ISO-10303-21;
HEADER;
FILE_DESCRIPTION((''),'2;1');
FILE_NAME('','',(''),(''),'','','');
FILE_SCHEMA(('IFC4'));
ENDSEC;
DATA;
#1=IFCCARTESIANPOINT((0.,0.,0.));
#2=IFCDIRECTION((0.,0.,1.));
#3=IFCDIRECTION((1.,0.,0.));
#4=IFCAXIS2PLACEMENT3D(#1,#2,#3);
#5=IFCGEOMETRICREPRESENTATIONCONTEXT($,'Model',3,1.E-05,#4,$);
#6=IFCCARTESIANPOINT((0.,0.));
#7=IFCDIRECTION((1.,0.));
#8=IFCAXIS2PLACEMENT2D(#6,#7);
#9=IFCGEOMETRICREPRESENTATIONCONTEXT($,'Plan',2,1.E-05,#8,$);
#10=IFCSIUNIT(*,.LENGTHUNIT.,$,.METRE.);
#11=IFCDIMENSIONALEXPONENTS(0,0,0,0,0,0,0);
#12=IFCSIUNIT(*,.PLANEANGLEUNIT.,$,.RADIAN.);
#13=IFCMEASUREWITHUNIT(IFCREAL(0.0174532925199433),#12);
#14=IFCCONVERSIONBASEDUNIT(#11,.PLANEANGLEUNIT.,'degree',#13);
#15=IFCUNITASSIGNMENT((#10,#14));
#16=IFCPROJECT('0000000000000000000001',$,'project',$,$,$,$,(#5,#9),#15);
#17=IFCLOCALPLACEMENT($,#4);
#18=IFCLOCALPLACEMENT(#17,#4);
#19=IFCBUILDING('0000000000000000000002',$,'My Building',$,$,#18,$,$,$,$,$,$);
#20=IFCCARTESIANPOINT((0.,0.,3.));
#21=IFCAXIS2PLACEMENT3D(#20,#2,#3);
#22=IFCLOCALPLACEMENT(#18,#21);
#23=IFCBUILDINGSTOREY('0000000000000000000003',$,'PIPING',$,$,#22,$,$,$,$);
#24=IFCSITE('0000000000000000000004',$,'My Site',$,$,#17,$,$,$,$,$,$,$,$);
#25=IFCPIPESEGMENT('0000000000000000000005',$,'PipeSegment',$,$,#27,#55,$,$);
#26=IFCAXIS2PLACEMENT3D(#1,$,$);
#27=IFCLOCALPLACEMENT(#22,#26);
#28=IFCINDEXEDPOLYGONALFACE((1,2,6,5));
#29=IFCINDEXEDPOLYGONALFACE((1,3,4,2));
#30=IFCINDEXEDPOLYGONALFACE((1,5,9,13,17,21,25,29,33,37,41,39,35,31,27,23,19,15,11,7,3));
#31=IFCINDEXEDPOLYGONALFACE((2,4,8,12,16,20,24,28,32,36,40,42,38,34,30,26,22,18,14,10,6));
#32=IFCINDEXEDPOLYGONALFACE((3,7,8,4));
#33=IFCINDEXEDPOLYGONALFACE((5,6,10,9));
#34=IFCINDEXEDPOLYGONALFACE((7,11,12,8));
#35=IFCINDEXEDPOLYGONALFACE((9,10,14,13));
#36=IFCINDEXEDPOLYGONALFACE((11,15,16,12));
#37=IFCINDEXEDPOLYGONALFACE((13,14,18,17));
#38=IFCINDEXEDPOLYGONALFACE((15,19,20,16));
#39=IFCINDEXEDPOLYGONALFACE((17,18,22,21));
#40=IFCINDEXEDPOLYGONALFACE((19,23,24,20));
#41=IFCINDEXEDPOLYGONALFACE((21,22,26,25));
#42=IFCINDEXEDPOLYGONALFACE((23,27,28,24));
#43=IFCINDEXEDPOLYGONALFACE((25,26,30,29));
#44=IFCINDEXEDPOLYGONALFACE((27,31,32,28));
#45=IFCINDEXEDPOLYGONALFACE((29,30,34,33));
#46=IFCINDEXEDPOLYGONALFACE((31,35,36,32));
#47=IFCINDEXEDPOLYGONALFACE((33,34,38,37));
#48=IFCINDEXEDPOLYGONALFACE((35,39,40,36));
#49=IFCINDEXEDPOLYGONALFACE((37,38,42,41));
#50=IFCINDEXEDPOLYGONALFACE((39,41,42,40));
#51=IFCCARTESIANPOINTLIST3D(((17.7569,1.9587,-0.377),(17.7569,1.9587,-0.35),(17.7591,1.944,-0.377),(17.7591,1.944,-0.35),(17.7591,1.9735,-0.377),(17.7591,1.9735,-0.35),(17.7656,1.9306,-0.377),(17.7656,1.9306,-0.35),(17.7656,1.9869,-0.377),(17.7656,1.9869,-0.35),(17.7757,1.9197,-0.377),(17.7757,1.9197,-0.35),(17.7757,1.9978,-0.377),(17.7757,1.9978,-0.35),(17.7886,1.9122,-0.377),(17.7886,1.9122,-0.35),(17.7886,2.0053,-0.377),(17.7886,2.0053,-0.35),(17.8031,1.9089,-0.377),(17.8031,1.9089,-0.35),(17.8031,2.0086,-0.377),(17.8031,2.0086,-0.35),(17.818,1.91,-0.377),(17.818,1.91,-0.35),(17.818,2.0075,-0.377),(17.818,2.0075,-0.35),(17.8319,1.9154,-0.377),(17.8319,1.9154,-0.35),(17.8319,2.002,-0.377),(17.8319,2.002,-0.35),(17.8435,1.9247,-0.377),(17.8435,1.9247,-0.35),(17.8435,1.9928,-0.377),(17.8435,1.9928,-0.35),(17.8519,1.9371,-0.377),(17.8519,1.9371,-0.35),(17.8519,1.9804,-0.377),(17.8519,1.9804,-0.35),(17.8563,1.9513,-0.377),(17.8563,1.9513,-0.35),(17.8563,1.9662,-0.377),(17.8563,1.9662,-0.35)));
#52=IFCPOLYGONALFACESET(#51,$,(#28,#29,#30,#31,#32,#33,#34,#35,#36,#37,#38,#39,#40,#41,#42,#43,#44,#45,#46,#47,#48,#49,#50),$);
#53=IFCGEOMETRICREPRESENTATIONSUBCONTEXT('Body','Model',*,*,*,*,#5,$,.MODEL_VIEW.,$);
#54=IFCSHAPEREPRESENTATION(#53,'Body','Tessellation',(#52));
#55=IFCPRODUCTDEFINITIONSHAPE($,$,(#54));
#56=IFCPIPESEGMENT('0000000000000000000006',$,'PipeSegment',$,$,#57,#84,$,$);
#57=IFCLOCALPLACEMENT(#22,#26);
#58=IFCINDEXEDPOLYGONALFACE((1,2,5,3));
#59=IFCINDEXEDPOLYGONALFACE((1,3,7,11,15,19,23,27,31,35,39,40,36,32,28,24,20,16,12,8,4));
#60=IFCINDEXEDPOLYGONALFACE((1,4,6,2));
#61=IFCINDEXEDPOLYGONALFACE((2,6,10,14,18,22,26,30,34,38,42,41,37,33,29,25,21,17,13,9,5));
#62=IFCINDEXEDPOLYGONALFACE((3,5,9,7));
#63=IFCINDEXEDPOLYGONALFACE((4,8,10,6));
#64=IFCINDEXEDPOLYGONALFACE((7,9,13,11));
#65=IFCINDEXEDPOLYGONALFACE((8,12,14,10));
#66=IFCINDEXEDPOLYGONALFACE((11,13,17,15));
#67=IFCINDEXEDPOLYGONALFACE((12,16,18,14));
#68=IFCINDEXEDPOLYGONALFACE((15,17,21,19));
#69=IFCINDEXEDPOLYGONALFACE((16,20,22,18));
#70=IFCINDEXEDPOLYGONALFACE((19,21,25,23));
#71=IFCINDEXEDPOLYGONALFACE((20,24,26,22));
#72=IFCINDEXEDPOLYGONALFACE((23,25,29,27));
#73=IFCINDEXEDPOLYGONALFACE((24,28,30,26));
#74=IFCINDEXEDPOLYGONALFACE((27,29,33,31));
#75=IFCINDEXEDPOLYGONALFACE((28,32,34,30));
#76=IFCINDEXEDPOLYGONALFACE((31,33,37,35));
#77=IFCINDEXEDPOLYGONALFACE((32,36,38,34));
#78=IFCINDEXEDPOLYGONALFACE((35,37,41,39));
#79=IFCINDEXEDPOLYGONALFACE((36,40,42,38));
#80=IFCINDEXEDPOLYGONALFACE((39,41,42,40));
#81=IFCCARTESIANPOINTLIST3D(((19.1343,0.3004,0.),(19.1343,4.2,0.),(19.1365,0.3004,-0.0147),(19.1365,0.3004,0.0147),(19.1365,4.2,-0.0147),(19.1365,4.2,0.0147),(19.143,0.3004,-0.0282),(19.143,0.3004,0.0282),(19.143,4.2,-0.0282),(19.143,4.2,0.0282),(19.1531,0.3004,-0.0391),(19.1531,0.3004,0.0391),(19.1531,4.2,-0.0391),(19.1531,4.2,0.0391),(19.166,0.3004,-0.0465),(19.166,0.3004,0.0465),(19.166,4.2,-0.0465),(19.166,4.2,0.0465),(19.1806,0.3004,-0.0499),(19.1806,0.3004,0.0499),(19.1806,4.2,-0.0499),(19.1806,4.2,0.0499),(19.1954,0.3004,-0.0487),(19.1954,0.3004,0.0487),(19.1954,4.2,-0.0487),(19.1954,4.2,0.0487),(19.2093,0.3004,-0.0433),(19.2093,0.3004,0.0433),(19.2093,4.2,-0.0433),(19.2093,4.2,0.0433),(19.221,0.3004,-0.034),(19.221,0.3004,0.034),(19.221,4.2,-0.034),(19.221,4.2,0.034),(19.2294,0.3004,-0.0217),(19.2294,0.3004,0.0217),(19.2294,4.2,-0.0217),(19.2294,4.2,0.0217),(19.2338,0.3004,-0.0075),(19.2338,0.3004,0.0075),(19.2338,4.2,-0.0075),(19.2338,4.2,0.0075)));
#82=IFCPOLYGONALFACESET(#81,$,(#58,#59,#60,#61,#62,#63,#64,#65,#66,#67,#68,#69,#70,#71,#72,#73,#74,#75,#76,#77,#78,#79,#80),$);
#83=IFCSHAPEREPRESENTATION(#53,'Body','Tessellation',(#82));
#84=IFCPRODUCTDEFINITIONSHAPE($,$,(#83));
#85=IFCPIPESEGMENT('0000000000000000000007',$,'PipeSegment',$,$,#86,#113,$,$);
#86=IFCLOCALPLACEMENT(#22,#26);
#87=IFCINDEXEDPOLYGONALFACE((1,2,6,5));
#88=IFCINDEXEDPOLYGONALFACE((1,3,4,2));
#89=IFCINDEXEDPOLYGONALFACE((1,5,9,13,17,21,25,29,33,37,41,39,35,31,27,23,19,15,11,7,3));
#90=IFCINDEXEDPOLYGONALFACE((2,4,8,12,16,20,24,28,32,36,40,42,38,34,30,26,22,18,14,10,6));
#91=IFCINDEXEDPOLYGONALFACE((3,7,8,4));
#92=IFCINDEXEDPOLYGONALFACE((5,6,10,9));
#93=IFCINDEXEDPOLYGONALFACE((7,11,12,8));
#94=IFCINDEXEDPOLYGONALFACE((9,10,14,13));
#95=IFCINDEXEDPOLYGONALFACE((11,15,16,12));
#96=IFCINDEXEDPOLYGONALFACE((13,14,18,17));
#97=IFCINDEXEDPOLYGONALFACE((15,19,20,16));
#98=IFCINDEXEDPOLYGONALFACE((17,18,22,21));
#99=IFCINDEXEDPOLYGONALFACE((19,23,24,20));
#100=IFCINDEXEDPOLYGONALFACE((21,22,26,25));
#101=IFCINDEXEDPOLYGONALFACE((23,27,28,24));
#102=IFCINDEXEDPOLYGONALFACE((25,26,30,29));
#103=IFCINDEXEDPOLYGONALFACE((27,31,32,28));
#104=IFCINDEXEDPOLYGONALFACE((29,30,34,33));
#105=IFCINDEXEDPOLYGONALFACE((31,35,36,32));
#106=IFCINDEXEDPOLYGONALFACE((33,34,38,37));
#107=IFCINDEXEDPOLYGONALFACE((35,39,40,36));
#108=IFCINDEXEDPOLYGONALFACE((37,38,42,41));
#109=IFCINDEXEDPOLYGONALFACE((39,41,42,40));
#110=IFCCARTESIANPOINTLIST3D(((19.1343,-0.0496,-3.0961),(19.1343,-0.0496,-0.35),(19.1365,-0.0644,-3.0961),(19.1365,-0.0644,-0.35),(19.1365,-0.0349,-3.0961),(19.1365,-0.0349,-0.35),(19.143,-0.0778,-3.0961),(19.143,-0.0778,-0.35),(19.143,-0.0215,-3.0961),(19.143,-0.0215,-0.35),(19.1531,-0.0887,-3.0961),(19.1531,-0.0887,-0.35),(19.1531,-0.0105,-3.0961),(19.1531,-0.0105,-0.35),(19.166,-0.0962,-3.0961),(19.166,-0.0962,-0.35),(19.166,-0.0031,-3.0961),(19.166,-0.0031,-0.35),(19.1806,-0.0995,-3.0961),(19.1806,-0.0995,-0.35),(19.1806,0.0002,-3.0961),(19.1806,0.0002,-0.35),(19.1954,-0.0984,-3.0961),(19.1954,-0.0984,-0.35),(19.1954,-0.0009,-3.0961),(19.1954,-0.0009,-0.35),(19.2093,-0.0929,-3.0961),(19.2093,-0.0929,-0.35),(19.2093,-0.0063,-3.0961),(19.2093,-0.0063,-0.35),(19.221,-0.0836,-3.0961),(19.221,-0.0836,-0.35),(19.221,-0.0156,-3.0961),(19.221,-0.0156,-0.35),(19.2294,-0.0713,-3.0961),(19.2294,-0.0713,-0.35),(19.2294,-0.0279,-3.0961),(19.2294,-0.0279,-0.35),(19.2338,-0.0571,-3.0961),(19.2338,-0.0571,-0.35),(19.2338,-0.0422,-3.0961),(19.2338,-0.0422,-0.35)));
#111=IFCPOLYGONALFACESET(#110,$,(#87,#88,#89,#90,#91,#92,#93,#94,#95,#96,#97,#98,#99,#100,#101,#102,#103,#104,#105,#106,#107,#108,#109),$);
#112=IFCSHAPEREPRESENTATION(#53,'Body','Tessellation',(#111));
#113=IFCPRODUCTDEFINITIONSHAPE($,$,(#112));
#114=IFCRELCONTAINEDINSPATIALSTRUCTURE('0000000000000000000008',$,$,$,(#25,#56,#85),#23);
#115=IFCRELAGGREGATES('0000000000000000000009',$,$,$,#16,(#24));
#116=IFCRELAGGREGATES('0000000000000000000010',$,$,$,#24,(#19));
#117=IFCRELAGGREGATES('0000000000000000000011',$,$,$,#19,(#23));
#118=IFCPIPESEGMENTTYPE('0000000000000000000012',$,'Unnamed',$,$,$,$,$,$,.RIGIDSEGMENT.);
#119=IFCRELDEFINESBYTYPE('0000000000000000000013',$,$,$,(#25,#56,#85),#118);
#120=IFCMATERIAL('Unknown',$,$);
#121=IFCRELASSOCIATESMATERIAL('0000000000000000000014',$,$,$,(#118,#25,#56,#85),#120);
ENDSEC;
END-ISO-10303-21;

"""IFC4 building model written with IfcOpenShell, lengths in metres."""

from ifc_helpers import new_model, entity, si_unit, converted_unit, frame, origin_with_axes, origin_2d_with_axis, place, context, subcontext, project, spatial, circle, extrude, material, material_profile, profile_set, profile_usage, type_object, element, save


model = new_model("IFC4")

# Units and contexts
model_context = context("Model", 3, precision=1e-05, world=origin_with_axes())
plan_context = context("Plan", 2, precision=1e-05, world=origin_2d_with_axis())
body_context = subcontext(model_context, "Body", "Model", "MODEL_VIEW")
ifc_project = project(units=[si_unit("LENGTHUNIT", "METRE"), converted_unit("PLANEANGLEUNIT", "degree", entity("IfcReal", 0.0174532925199433), si_unit("PLANEANGLEUNIT", "RADIAN"), dimensions=[0, 0, 0, 0, 0, 0, 0])], contexts=[model_context, plan_context])

# Site, building, storey
site_placement = place(None, origin_with_axes())
site = spatial("IfcSite", under=ifc_project, at=site_placement, Name="My Site")
building_placement = place(site_placement, origin_with_axes())
building = spatial("IfcBuilding", under=site, at=building_placement, Name="My Building")
storey_placement = place(building_placement, frame((0.0, 0.0, 3.0), z_axis=(0.0, 0.0, 1.0), x_axis=(1.0, 0.0, 0.0)))
storey = spatial("IfcBuildingStorey", under=building, at=storey_placement, Name="PIPING")

# Pipe segments
ifc_material = material(Name="Unknown")
ifc_material_profile = material_profile(ifc_material, circle(Radius=0.05))
ifc_profile_set = profile_set([ifc_material_profile])
pipe_segment_type = type_object("IfcPipeSegmentType", Name="Unnamed", PredefinedType="RIGIDSEGMENT", material=ifc_profile_set)
ifc_profile_usage_1 = profile_usage(ifc_profile_set, cardinal=5)
pipe_segment_1_placement = place(storey_placement, frame((17.8069, 1.9587, -0.35), z_axis=(0.0, 0.0, -1.0), x_axis=(-1.0, 0.0, 0.0)))
element("IfcPipeSegment", 1, at=pipe_segment_1_placement, inside=storey, type_object=pipe_segment_type, material=ifc_profile_usage_1, Name="PipeSegment", context=body_context, shape_type="SweptSolid", body=[
    extrude(circle(Radius=0.05), origin_with_axes(), (0.0, 0.0, 1.0), 0.027),
])
ifc_profile_usage_2 = profile_usage(ifc_profile_set, cardinal=5)
pipe_segment_2_placement = place(storey_placement, frame((19.1843, 0.3004, 0.0), z_axis=(0.0, 1.0, 0.0), x_axis=(-1.0, 0.0, 0.0)))
element("IfcPipeSegment", 2, at=pipe_segment_2_placement, inside=storey, type_object=pipe_segment_type, material=ifc_profile_usage_2, Name="PipeSegment", context=body_context, shape_type="SweptSolid", body=[
    extrude(circle(Radius=0.05), origin_with_axes(), (0.0, 0.0, 1.0), 3.8996),
])
ifc_profile_usage_3 = profile_usage(ifc_profile_set, cardinal=5)
pipe_segment_3_placement = place(storey_placement, frame((19.1843, -0.0496, -3.0961), z_axis=(0.0, 0.0, 1.0), x_axis=(-1.0, 0.0, 0.0)))
element("IfcPipeSegment", 3, at=pipe_segment_3_placement, inside=storey, type_object=pipe_segment_type, material=ifc_profile_usage_3, Name="PipeSegment", context=body_context, shape_type="SweptSolid", body=[
    extrude(circle(Radius=0.05), origin_with_axes(), (0.0, 0.0, 1.0), 2.7461),
])

save(model, "model.ifc")
